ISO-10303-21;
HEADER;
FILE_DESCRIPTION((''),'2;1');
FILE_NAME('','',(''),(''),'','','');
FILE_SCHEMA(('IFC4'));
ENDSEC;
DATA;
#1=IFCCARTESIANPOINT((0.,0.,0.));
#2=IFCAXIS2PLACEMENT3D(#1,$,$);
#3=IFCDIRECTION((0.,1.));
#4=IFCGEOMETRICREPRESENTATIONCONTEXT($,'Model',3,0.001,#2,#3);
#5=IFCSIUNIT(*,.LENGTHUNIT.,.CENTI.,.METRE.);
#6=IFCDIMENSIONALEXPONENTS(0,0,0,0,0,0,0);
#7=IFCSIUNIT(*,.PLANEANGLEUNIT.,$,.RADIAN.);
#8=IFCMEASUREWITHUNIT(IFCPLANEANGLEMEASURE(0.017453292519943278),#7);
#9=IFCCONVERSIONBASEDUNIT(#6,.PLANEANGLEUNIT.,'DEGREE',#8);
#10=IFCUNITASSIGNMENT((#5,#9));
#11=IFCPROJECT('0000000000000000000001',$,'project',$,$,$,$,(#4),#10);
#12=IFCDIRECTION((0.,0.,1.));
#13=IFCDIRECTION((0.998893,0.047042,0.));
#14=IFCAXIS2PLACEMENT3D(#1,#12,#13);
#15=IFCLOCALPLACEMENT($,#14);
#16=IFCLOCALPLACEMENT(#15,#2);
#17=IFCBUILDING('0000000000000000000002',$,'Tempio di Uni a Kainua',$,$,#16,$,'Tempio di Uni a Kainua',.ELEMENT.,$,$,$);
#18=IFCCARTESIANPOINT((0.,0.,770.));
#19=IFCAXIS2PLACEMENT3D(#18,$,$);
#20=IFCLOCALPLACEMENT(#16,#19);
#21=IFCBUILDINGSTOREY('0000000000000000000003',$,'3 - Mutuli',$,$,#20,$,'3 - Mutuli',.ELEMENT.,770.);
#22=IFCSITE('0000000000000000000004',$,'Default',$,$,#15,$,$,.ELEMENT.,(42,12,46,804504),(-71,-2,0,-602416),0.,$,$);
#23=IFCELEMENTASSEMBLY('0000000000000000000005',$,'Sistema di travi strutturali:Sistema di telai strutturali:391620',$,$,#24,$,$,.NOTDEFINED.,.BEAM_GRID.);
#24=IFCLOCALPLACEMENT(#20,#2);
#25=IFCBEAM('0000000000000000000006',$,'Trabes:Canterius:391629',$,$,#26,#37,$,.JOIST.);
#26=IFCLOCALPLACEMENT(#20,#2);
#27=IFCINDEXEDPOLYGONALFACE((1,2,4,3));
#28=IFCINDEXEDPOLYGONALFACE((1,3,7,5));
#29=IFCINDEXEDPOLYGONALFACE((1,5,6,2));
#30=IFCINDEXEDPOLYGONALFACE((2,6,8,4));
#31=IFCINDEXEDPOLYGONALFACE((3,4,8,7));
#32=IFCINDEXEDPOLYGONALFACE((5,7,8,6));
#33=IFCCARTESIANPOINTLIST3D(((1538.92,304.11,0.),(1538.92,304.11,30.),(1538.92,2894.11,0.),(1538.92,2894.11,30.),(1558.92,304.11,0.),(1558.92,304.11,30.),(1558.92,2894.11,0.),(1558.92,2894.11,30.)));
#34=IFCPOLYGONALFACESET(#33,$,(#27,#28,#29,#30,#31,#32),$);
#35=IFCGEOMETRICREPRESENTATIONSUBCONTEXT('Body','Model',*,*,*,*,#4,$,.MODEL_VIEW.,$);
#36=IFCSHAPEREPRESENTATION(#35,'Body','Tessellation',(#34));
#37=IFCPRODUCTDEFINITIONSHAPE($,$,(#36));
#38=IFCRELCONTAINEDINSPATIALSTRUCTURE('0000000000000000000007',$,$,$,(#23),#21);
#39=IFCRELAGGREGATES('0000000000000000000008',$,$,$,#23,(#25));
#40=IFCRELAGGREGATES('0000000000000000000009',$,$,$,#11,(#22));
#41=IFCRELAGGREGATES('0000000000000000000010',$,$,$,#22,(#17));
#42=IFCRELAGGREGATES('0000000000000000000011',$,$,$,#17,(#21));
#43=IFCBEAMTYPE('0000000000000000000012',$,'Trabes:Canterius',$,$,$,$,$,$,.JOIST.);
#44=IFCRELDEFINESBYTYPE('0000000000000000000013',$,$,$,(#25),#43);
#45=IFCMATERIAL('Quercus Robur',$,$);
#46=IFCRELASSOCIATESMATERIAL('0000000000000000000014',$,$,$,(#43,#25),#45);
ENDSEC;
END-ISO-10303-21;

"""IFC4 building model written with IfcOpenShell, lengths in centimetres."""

from ifc_helpers import new_model, entity, si_unit, converted_unit, direction, frame, origin, origin_2d_with_axis, place, context, subcontext, project, spatial, rectangle, extrude, source, transform, mapped, material, material_profile, profile_set, profile_usage, type_object, type_shapes, element, aggregate, save


model = new_model("IFC4")

# Units and contexts
model_context = context("Model", 3, precision=0.001, world=origin(), true_north=direction((0.0, 1.0)))
body_context = subcontext(model_context, "Body", "Model", "MODEL_VIEW")
ifc_project = project(units=[si_unit("LENGTHUNIT", "METRE", prefix="CENTI"), converted_unit("PLANEANGLEUNIT", "DEGREE", entity("IfcPlaneAngleMeasure", 0.017453292519943278), si_unit("PLANEANGLEUNIT", "RADIAN"), dimensions=[0, 0, 0, 0, 0, 0, 0])], contexts=[model_context])

# Site, building, storey
site_placement = place(None, frame((0.0, 0.0, 0.0), z_axis=(0.0, 0.0, 1.0), x_axis=(0.998893, 0.047042, 0.0)))
site = spatial("IfcSite", under=ifc_project, at=site_placement, Name="Default", CompositionType="ELEMENT", RefLatitude=(42, 12, 46, 804504), RefLongitude=(-71, -2, 0, -602416), RefElevation=0.0)
building_placement = place(site_placement, origin())
building = spatial("IfcBuilding", under=site, at=building_placement, Name="Tempio di Uni a Kainua", LongName="Tempio di Uni a Kainua", CompositionType="ELEMENT")
storey_placement = place(building_placement, frame((0.0, 0.0, 770.0)))
storey = spatial("IfcBuildingStorey", under=building, at=storey_placement, Name="3 - Mutuli", LongName="3 - Mutuli", CompositionType="ELEMENT", Elevation=770.0)

# Shared definitions
ifc_material = material(Name="Quercus Robur")

# Shared definitions
ifc_material_profile_1 = material_profile(ifc_material, rectangle(XDim=2590.0, YDim=20.0, at=origin_2d_with_axis()), Name="Canterius")
ifc_profile_set_1 = profile_set([ifc_material_profile_1], Name="Canterius")
ifc_profile_usage_1 = profile_usage(ifc_profile_set_1, cardinal=3)
beam_type_1 = type_object("IfcBeamType", Name="Trabes:Canterius", PredefinedType="JOIST", material=ifc_profile_set_1)
shared_shape_1 = source(origin(), body_context, "Body", "SweptSolid", [
    extrude(rectangle(XDim=2590.0, YDim=20.0, at=origin_2d_with_axis()), frame((-80.0, 0.0, -15.0)), (0.0, 0.0, 1.0), 30.0),
])
type_shapes(beam_type_1, [shared_shape_1])

# Element assembly, beam
assembly_1_placement = place(storey_placement, origin())
assembly_1 = element("IfcElementAssembly", 1, at=assembly_1_placement, inside=storey, Name="Sistema di travi strutturali:Sistema di telai strutturali:391620", AssemblyPlace="NOTDEFINED", PredefinedType="BEAM_GRID")
beam_1_placement = place(assembly_1_placement, frame((1548.92, 1679.11, 15.0), z_axis=(0.0, 0.0, 1.0), x_axis=(0.0, 1.0, 0.0)))
beam_1 = element("IfcBeam", 2, at=beam_1_placement, type_object=beam_type_1, material=ifc_profile_usage_1, Name="Trabes:Canterius:391629", PredefinedType="JOIST", context=body_context, shape_type="MappedRepresentation", body=[
    mapped(shared_shape_1, transform((0.0, 0.0, 0.0), scale=1.0)),
])
aggregate(assembly_1, [beam_1])

save(model, "model.ifc")
